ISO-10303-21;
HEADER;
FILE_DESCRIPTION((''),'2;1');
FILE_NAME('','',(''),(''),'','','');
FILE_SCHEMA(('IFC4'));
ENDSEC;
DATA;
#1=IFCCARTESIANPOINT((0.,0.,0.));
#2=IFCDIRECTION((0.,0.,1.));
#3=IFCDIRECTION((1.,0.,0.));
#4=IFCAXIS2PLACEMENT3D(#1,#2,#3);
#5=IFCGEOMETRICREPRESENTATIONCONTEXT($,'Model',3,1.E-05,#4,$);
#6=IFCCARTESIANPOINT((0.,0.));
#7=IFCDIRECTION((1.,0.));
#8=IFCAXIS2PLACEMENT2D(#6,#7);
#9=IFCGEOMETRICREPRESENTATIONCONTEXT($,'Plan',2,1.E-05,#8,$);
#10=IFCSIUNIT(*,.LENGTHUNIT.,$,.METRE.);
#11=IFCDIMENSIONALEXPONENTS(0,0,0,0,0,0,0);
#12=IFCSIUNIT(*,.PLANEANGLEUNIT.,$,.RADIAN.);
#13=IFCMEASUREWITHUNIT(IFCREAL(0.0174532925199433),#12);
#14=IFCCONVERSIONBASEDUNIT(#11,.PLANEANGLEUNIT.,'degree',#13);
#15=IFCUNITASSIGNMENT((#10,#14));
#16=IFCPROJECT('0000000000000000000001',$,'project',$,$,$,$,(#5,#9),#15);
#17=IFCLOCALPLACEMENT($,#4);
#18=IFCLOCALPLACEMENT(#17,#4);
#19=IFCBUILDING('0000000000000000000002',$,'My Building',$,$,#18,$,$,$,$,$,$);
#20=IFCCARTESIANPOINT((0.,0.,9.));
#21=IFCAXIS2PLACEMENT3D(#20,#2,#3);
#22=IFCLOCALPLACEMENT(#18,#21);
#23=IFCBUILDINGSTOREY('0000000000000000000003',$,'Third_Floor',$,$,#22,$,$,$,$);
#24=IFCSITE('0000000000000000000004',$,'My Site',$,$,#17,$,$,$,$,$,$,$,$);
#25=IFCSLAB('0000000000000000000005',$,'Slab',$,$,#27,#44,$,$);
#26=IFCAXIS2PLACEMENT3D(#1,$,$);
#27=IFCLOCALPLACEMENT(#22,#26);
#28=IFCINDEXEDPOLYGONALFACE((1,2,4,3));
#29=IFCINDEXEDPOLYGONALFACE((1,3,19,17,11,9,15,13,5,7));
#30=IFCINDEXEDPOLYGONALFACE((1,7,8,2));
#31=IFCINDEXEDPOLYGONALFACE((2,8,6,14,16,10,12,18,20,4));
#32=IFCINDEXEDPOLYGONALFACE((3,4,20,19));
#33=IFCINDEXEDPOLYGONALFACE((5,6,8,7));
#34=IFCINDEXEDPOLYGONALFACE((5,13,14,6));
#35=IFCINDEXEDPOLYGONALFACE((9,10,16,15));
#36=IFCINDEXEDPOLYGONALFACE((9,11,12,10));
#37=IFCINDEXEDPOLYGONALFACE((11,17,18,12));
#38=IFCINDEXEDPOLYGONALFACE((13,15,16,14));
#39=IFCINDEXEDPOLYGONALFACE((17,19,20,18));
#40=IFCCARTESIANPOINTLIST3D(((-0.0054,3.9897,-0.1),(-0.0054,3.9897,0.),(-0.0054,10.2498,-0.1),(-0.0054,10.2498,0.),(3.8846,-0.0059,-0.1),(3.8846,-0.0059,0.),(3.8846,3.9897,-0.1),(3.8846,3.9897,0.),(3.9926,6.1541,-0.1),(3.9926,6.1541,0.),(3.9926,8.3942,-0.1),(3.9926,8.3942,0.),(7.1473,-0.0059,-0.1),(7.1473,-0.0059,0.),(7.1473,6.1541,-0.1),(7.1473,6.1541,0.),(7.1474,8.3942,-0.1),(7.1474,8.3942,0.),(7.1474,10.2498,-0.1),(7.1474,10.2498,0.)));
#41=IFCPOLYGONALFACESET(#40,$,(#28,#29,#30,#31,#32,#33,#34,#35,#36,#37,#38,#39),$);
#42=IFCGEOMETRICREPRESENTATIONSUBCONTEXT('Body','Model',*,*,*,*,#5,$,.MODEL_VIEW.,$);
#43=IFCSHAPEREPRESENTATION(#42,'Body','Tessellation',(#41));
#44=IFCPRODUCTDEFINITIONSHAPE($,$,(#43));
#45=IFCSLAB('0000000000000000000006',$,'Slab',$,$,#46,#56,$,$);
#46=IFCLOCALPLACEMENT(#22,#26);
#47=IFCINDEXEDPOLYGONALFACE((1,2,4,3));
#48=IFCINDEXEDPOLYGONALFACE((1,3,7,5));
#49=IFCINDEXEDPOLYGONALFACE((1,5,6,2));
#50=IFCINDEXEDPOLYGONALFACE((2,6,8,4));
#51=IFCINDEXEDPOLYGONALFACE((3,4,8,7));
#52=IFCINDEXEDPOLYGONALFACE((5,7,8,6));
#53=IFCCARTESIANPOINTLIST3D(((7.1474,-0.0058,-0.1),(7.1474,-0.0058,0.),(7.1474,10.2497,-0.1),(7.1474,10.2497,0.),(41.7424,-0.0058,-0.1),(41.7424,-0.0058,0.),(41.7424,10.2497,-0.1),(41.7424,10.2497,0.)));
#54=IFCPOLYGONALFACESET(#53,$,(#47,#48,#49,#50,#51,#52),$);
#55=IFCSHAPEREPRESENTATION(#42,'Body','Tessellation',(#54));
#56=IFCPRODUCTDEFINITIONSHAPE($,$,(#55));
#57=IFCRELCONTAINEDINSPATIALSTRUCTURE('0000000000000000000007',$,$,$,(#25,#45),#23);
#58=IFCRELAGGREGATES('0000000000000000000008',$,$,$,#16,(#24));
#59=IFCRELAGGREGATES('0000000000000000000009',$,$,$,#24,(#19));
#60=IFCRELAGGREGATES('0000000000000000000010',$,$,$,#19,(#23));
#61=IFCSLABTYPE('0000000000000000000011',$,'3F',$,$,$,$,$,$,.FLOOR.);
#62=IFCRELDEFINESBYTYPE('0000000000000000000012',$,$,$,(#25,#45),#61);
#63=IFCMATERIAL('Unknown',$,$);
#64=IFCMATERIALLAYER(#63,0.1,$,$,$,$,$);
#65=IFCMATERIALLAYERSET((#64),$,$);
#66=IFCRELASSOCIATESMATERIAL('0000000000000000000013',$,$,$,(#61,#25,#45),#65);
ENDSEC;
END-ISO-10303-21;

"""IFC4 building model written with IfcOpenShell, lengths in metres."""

from ifc_helpers import new_model, entity, si_unit, converted_unit, frame, origin_with_axes, origin_2d_with_axis, place, context, subcontext, project, spatial, indexed_curve, outline, extrude, material, layer, layer_set, layer_usage, type_object, element, save


model = new_model("IFC4")

# Units and contexts
model_context = context("Model", 3, precision=1e-05, world=origin_with_axes())
plan_context = context("Plan", 2, precision=1e-05, world=origin_2d_with_axis())
body_context = subcontext(model_context, "Body", "Model", "MODEL_VIEW")
ifc_project = project(units=[si_unit("LENGTHUNIT", "METRE"), converted_unit("PLANEANGLEUNIT", "degree", entity("IfcReal", 0.0174532925199433), si_unit("PLANEANGLEUNIT", "RADIAN"), dimensions=[0, 0, 0, 0, 0, 0, 0])], contexts=[model_context, plan_context])

# Site, building, storey
site_placement = place(None, origin_with_axes())
site = spatial("IfcSite", under=ifc_project, at=site_placement, Name="My Site")
building_placement = place(site_placement, origin_with_axes())
building = spatial("IfcBuilding", under=site, at=building_placement, Name="My Building")
storey_placement = place(building_placement, frame((0.0, 0.0, 9.0), z_axis=(0.0, 0.0, 1.0), x_axis=(1.0, 0.0, 0.0)))
storey = spatial("IfcBuildingStorey", under=building, at=storey_placement, Name="Third_Floor")

# Shared definitions
ifc_material = material(Name="Unknown")

# Slabs
ifc_layer = layer(ifc_material, 0.1)
ifc_layer_set = layer_set([ifc_layer])
ifc_layer_usage_1 = layer_usage(ifc_layer_set, "AXIS3", "POSITIVE", -0.1)
slab_type = type_object("IfcSlabType", Name="3F", PredefinedType="FLOOR", material=ifc_layer_set)
slab_1_placement = place(storey_placement, frame((-0.0054, -0.0059, 0.0), z_axis=(0.0, 0.0, 1.0), x_axis=(1.0, 0.0, 0.0)))
element("IfcSlab", 1, at=slab_1_placement, inside=storey, type_object=slab_type, material=ifc_layer_usage_1, Name="Slab", context=body_context, shape_type="SweptSolid", body=[
    extrude(outline(indexed_curve([(0.0, 0.0), (7.1527, 0.0), (7.1527, 6.16), (3.998, 6.16), (3.998, 8.4), (7.1528, 8.4), (7.1528, 10.2556), (0.0, 10.2556), (0.0, 3.9956), (3.89, 3.9956), (3.89, -0.0001), (0.0, 0.0)])), frame((0.0, 0.0, -0.1), z_axis=(0.0, 0.0, 1.0), x_axis=(1.0, 0.0, 0.0)), (0.0, 0.0, 1.0), 0.1),
])
ifc_layer_usage_2 = layer_usage(ifc_layer_set, "AXIS3", "POSITIVE", -0.1)
slab_2_placement = place(storey_placement, frame((7.1474, 10.2497, 0.0), z_axis=(0.0, 0.0, 1.0), x_axis=(1.0, 0.0, 0.0)))
element("IfcSlab", 2, at=slab_2_placement, inside=storey, type_object=slab_type, material=ifc_layer_usage_2, Name="Slab", context=body_context, shape_type="SweptSolid", body=[
    extrude(outline(indexed_curve([(0.0, 0.0), (34.595, 0.0), (34.595, -10.2555), (0.0, -10.2555), (0.0, 0.0)])), frame((0.0, 0.0, -0.1), z_axis=(0.0, 0.0, 1.0), x_axis=(1.0, 0.0, 0.0)), (0.0, 0.0, 1.0), 0.1),
])

save(model, "model.ifc")
